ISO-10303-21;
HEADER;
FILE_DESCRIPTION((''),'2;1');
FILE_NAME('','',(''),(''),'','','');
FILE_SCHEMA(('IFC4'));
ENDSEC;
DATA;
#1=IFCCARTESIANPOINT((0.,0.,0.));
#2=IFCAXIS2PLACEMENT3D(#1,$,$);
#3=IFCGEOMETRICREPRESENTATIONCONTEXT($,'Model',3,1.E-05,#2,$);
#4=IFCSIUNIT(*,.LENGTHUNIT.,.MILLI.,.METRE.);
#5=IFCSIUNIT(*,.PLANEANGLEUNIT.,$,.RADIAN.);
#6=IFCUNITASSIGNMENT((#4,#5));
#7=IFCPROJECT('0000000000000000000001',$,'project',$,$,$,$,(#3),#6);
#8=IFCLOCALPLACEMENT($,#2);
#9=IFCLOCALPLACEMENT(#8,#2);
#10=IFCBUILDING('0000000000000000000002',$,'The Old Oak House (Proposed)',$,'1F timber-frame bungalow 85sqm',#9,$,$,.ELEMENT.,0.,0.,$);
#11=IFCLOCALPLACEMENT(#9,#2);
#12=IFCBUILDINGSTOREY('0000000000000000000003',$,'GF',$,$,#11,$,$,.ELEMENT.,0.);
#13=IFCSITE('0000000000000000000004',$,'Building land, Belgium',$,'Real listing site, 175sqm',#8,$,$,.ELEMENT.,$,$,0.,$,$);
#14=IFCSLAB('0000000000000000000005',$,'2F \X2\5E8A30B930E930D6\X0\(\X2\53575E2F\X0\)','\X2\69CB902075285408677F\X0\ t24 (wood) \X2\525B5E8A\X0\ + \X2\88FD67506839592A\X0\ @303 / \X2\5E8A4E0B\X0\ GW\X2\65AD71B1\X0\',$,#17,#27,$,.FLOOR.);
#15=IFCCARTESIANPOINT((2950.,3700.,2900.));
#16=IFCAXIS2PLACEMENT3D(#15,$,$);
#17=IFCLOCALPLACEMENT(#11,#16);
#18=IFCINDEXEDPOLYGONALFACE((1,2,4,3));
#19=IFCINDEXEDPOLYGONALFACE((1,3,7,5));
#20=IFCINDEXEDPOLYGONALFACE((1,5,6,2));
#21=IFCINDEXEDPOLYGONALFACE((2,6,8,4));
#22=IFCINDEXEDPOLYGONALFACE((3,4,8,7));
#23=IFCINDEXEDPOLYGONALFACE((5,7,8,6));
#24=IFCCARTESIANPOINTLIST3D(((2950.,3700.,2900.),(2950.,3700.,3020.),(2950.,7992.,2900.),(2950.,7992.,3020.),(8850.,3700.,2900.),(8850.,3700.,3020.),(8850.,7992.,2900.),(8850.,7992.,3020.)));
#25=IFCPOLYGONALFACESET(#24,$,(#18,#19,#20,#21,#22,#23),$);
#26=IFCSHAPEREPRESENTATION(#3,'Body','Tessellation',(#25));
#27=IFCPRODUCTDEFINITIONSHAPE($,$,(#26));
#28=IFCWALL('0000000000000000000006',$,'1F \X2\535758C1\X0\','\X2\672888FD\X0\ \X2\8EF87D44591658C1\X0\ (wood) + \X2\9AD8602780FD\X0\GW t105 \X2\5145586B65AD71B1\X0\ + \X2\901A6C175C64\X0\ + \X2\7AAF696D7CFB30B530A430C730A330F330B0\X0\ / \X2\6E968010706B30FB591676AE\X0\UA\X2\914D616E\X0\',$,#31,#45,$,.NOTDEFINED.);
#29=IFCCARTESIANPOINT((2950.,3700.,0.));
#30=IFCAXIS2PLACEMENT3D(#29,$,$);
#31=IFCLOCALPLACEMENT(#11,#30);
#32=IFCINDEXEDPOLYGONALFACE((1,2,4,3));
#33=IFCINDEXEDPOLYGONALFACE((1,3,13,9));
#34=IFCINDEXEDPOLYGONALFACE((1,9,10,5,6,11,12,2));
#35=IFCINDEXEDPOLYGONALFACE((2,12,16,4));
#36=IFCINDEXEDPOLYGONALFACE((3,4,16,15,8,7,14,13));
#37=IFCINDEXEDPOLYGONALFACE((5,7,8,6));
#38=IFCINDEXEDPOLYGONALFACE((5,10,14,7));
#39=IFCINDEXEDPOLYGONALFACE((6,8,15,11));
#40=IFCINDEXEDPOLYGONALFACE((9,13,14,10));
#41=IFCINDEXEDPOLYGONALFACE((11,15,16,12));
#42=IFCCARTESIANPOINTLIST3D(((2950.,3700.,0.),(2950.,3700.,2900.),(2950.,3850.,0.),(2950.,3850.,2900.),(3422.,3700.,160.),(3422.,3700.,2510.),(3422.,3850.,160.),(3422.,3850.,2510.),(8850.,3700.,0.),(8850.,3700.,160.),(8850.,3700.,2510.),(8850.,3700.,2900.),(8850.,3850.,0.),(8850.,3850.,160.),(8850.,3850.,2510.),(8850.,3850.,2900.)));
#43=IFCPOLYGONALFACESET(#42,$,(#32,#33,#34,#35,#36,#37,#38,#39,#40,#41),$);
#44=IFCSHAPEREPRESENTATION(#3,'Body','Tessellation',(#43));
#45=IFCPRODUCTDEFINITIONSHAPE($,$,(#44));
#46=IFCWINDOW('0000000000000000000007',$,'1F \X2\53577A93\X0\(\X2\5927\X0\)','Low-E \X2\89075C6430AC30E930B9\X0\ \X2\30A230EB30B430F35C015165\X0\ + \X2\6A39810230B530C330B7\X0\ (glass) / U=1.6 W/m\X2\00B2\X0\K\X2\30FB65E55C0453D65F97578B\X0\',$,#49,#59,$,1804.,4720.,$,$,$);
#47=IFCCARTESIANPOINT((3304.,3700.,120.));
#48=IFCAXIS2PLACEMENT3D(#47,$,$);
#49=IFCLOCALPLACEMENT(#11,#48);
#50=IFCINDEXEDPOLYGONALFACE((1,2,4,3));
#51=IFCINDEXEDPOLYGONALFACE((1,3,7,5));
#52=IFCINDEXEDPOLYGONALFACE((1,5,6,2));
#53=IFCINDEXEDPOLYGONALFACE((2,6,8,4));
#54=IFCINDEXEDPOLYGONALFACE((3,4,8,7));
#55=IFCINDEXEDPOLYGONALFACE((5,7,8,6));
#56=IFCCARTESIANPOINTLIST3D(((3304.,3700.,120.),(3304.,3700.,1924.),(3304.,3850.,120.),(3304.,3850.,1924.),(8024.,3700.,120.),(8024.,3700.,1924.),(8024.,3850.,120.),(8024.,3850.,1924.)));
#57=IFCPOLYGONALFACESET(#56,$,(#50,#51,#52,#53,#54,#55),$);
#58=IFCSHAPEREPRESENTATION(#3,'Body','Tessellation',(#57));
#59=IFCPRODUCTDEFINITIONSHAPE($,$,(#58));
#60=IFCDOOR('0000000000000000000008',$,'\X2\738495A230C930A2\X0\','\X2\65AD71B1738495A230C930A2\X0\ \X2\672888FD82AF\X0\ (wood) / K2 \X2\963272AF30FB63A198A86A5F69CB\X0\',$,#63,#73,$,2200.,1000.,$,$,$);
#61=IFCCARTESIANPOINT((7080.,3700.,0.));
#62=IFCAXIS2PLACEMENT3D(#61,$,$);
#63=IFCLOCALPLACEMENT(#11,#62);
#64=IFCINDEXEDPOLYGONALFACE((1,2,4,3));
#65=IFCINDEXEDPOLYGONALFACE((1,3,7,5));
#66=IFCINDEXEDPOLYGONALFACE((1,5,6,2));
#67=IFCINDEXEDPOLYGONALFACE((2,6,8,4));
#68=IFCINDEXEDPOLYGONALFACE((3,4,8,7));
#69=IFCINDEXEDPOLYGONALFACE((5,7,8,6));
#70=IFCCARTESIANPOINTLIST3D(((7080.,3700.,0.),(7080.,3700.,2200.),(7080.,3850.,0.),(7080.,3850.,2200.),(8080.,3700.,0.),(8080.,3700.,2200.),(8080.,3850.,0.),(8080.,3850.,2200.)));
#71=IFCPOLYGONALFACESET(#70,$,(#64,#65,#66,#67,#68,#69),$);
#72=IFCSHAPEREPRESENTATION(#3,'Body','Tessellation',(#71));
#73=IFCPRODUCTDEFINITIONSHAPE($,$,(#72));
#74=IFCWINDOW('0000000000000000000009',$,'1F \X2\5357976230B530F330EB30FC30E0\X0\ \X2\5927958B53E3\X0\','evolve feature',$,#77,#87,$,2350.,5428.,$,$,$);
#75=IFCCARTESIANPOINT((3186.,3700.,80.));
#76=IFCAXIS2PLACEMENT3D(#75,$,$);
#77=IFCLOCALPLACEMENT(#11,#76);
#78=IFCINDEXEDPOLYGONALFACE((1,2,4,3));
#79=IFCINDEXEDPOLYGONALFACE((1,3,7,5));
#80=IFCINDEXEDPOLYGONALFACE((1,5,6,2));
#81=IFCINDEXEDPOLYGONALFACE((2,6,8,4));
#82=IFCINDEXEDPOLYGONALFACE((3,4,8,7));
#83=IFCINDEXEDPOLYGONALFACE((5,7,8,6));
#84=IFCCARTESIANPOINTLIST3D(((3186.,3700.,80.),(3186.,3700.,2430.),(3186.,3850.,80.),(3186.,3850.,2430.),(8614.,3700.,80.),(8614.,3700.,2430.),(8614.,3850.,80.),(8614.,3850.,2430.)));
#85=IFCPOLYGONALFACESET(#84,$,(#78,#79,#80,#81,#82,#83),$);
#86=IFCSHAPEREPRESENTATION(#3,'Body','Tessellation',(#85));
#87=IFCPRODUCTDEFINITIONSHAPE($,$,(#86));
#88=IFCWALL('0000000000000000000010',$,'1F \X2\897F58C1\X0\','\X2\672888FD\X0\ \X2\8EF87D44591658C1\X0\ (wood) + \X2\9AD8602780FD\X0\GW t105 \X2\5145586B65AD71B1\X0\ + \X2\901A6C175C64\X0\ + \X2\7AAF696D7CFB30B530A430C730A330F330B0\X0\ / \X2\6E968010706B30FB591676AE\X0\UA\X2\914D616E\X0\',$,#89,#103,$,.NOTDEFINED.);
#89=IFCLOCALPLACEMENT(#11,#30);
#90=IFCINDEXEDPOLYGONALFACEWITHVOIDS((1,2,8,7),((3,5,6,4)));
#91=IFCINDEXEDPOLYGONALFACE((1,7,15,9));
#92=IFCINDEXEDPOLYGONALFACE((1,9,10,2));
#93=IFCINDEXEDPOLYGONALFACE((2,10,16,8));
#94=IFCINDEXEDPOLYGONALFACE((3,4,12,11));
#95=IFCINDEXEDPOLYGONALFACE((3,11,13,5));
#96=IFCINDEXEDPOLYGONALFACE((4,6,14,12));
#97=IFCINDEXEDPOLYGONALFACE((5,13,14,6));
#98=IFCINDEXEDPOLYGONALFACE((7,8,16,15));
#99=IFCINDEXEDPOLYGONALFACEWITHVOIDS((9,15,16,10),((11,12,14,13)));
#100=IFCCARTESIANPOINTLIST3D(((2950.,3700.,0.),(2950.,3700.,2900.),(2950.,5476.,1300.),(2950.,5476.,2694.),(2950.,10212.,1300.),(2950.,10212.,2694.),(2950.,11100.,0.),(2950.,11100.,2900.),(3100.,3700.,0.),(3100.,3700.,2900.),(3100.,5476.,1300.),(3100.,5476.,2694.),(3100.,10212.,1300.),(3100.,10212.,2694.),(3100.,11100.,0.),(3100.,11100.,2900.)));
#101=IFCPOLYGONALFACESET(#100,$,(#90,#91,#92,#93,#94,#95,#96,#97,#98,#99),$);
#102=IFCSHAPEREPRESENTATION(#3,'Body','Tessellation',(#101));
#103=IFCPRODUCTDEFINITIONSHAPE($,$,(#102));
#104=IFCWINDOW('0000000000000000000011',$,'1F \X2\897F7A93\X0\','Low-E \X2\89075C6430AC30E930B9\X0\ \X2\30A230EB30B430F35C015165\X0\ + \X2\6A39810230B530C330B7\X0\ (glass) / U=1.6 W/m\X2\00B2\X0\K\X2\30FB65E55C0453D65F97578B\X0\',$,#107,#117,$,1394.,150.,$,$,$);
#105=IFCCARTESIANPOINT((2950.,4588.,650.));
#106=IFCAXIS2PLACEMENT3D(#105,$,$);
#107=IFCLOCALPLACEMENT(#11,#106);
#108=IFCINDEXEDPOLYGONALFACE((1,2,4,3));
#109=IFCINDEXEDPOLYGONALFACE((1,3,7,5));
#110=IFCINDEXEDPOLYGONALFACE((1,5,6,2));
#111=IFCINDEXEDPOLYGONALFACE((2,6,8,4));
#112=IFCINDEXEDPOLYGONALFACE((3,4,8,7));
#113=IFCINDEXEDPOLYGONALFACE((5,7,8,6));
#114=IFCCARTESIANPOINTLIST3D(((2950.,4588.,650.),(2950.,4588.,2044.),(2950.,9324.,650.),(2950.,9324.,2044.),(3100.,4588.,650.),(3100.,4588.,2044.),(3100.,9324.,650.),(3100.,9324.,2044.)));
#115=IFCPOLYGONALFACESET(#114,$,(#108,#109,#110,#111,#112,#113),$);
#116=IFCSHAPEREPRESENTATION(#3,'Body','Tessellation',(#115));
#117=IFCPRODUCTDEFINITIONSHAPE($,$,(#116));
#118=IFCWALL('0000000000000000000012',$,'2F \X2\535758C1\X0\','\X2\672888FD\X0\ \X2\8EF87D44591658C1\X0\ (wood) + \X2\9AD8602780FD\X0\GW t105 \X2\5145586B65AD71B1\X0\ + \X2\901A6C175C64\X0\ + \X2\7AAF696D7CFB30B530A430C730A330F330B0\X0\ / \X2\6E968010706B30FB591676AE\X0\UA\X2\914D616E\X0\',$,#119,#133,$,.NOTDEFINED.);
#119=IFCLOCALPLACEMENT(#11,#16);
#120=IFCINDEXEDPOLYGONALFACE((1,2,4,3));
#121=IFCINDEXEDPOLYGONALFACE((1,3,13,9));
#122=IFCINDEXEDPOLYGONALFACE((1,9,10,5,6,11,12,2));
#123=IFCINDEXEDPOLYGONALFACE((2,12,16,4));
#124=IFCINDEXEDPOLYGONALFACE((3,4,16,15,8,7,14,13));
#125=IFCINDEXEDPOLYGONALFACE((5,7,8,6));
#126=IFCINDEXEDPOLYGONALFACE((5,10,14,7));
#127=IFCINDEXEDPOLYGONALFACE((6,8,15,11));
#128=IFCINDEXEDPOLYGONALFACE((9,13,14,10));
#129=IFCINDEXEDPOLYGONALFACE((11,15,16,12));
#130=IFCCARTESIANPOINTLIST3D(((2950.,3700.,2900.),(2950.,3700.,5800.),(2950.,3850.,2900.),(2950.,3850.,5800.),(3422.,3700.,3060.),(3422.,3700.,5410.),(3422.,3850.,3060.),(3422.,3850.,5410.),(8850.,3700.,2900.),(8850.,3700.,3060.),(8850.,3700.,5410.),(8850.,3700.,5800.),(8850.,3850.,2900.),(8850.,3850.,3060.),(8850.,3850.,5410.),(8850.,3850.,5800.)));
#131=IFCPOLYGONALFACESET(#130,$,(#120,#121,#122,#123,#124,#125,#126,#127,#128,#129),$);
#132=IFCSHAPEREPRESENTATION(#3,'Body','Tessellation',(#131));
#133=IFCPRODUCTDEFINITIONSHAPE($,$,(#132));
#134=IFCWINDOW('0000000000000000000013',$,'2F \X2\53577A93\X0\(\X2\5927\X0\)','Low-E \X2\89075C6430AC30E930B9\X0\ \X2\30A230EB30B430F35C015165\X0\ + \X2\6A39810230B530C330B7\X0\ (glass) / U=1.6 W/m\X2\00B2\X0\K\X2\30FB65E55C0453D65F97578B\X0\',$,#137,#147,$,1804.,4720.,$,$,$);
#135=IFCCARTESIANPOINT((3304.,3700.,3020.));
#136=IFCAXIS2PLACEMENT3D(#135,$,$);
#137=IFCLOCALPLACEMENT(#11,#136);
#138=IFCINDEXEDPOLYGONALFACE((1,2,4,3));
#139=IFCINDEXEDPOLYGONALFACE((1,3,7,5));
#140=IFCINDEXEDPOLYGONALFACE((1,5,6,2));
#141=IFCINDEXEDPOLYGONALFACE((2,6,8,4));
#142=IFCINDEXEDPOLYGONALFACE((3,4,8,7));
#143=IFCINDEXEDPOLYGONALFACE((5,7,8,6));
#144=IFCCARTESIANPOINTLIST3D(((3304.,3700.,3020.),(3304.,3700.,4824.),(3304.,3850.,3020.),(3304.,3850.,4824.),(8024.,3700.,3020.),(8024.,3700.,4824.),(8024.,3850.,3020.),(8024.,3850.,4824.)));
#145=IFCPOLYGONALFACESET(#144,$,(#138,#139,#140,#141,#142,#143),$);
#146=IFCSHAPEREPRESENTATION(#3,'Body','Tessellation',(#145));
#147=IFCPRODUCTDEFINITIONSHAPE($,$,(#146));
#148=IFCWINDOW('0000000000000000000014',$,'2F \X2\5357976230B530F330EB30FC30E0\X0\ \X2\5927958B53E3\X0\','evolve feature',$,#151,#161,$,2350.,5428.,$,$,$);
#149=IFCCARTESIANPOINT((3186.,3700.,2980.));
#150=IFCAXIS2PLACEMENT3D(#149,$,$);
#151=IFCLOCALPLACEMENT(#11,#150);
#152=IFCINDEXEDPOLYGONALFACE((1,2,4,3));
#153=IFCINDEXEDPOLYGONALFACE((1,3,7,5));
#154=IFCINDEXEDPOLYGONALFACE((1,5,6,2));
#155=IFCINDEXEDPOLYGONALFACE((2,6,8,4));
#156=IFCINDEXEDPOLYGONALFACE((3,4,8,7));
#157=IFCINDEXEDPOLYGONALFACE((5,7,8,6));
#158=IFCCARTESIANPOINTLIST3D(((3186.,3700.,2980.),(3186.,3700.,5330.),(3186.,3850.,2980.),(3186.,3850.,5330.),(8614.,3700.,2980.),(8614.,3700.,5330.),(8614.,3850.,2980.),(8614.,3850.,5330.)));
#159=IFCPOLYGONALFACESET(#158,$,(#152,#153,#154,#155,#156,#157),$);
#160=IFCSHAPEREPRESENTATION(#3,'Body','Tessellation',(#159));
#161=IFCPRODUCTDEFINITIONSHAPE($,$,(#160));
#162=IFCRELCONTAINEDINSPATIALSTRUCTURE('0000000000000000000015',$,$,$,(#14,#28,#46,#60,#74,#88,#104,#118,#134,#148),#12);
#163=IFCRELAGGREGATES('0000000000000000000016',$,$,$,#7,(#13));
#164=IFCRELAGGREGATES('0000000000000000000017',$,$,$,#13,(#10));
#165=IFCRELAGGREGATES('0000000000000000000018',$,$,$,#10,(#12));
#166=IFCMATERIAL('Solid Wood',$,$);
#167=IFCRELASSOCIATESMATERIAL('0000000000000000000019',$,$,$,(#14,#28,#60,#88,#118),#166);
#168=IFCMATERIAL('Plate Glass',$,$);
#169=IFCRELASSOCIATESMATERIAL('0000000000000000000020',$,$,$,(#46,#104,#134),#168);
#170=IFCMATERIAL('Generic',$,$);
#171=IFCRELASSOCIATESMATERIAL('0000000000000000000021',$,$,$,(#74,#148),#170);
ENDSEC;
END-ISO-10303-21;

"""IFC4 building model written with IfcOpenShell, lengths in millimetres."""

from ifc_helpers import new_model, si_unit, frame, frame_2d, origin, place, context, project, spatial, rectangle, extrude, material, element, fill, save


model = new_model("IFC4")

# Units and contexts
model_context = context("Model", 3, precision=1e-05, world=origin())
ifc_project = project(units=[si_unit("LENGTHUNIT", "METRE", prefix="MILLI"), si_unit("PLANEANGLEUNIT", "RADIAN")], contexts=[model_context])

# Site, building, storey
site_placement = place(None, origin())
site = spatial("IfcSite", under=ifc_project, at=site_placement, Name="Building land, Belgium", ObjectType="Real listing site, 175sqm", CompositionType="ELEMENT", RefElevation=0.0)
building_placement = place(site_placement, origin())
building = spatial("IfcBuilding", under=site, at=building_placement, Name="The Old Oak House (Proposed)", ObjectType="1F timber-frame bungalow 85sqm", CompositionType="ELEMENT", ElevationOfRefHeight=0.0, ElevationOfTerrain=0.0)
storey_placement = place(building_placement, origin())
storey = spatial("IfcBuildingStorey", under=building, at=storey_placement, Name="GF", CompositionType="ELEMENT", Elevation=0.0)

# Slab
ifc_material_1 = material(Name="Solid Wood")
slab_1_placement = place(storey_placement, frame((2950.0, 3700.0, 2900.0)))
element("IfcSlab", 1, at=slab_1_placement, inside=storey, material=ifc_material_1, Name="2F 床スラブ(南帯)", Description="構造用合板 t24 (wood) 剛床 + 製材根太 @303 / 床下 GW断熱", PredefinedType="FLOOR", context=model_context, shape_type="SweptSolid", body=[
    extrude(rectangle(XDim=5900.0, YDim=4292.0, at=frame_2d((2950.0, 2146.0))), frame((2950.0, 3700.0, 2900.0)), (0.0, 0.0, 1.0), 120.0),
])
ifc_material_2 = material(Name="Generic")

# Wall, openings, windows, door
wall_1_placement = place(storey_placement, frame((2950.0, 3700.0, 0.0)))
wall_1 = element("IfcWall", 2, at=wall_1_placement, inside=storey, material=ifc_material_1, Name="1F 南壁", Description="木製 軸組外壁 (wood) + 高性能GW t105 充填断熱 + 通気層 + 窯業系サイディング / 準耐火・外皮UA配慮", PredefinedType="NOTDEFINED", context=model_context, shape_type="SweptSolid", body=[
    extrude(rectangle(XDim=5900.0, YDim=150.0, at=frame_2d((2950.0, 75.0))), frame((2950.0, 3700.0, 0.0)), (0.0, 0.0, 1.0), 2900.0),
])
opening_1_placement = place(storey_placement, frame((3304.0, 3700.0, 120.0)))
opening_1 = element("IfcOpeningElement", 3, at=opening_1_placement, cuts=wall_1, PredefinedType="NOTDEFINED", context=model_context, shape_type="SweptSolid", body=[
    extrude(rectangle(XDim=4720.0, YDim=150.0, at=frame_2d((2360.0, 75.0))), frame((3304.0, 3700.0, 120.0)), (0.0, 0.0, 1.0), 1804.0),
])
opening_2_placement = place(storey_placement, frame((7080.0, 3700.0, 0.0)))
opening_2 = element("IfcOpeningElement", 4, at=opening_2_placement, cuts=wall_1, PredefinedType="NOTDEFINED", context=model_context, shape_type="SweptSolid", body=[
    extrude(rectangle(XDim=1000.0, YDim=150.0, at=frame_2d((500.0, 75.0))), frame((7080.0, 3700.0, 0.0)), (0.0, 0.0, 1.0), 2200.0),
])
opening_3_placement = place(storey_placement, frame((3186.0, 3700.0, 80.0)))
opening_3 = element("IfcOpeningElement", 5, at=opening_3_placement, cuts=wall_1, PredefinedType="NOTDEFINED", context=model_context, shape_type="SweptSolid", body=[
    extrude(rectangle(XDim=5428.0, YDim=150.0, at=frame_2d((2714.0, 75.0))), frame((3186.0, 3700.0, 80.0)), (0.0, 0.0, 1.0), 2350.0),
])
ifc_material_3 = material(Name="Plate Glass")
window_1_placement = place(storey_placement, frame((3304.0, 3700.0, 120.0)))
window_1 = element("IfcWindow", 6, at=window_1_placement, inside=storey, material=ifc_material_3, Name="1F 南窓(大)", Description="Low-E 複層ガラス アルゴン封入 + 樹脂サッシ (glass) / U=1.6 W/m²K・日射取得型", OverallHeight=1804.0, OverallWidth=4720.0, context=model_context, shape_type="SweptSolid", body=[
    extrude(rectangle(XDim=4720.0, YDim=150.0, at=frame_2d((2360.0, 75.0))), frame((3304.0, 3700.0, 120.0)), (0.0, 0.0, 1.0), 1804.0),
])
fill(opening_1, window_1)
door_placement = place(storey_placement, frame((7080.0, 3700.0, 0.0)))
door = element("IfcDoor", 7, at=door_placement, inside=storey, material=ifc_material_1, Name="玄関ドア", Description="断熱玄関ドア 木製芯 (wood) / K2 防犯・採風機構", OverallHeight=2200.0, OverallWidth=1000.0, context=model_context, shape_type="SweptSolid", body=[
    extrude(rectangle(XDim=1000.0, YDim=150.0, at=frame_2d((500.0, 75.0))), frame((7080.0, 3700.0, 0.0)), (0.0, 0.0, 1.0), 2200.0),
])
fill(opening_2, door)
window_2_placement = place(storey_placement, frame((3186.0, 3700.0, 80.0)))
window_2 = element("IfcWindow", 8, at=window_2_placement, inside=storey, material=ifc_material_2, Name="1F 南面サンルーム 大開口", Description="evolve feature", OverallHeight=2350.0, OverallWidth=5428.0, context=model_context, shape_type="SweptSolid", body=[
    extrude(rectangle(XDim=5428.0, YDim=150.0, at=frame_2d((2714.0, 75.0))), frame((3186.0, 3700.0, 80.0)), (0.0, 0.0, 1.0), 2350.0),
])
fill(opening_3, window_2)

# Wall, opening, window
wall_2_placement = place(storey_placement, frame((2950.0, 3700.0, 0.0)))
wall_2 = element("IfcWall", 9, at=wall_2_placement, inside=storey, material=ifc_material_1, Name="1F 西壁", Description="木製 軸組外壁 (wood) + 高性能GW t105 充填断熱 + 通気層 + 窯業系サイディング / 準耐火・外皮UA配慮", PredefinedType="NOTDEFINED", context=model_context, shape_type="SweptSolid", body=[
    extrude(rectangle(XDim=150.0, YDim=7400.0, at=frame_2d((75.0, 3700.0))), frame((2950.0, 3700.0, 0.0)), (0.0, 0.0, 1.0), 2900.0),
])
opening_4_placement = place(storey_placement, frame((2950.0, 4588.0, 650.0)))
opening_4 = element("IfcOpeningElement", 10, at=opening_4_placement, cuts=wall_2, PredefinedType="NOTDEFINED", context=model_context, shape_type="SweptSolid", body=[
    extrude(rectangle(XDim=150.0, YDim=4736.0, at=frame_2d((75.0, 2368.0))), frame((2950.0, 4588.0, 650.0)), (0.0, 0.0, 1.0), 1394.0),
])
window_3_placement = place(storey_placement, frame((2950.0, 4588.0, 650.0)))
window_3 = element("IfcWindow", 11, at=window_3_placement, inside=storey, material=ifc_material_3, Name="1F 西窓", Description="Low-E 複層ガラス アルゴン封入 + 樹脂サッシ (glass) / U=1.6 W/m²K・日射取得型", OverallHeight=1394.0, OverallWidth=150.0, context=model_context, shape_type="SweptSolid", body=[
    extrude(rectangle(XDim=150.0, YDim=4736.0, at=frame_2d((75.0, 2368.0))), frame((2950.0, 4588.0, 650.0)), (0.0, 0.0, 1.0), 1394.0),
])
fill(opening_4, window_3)

# Wall, openings, windows
wall_3_placement = place(storey_placement, frame((2950.0, 3700.0, 2900.0)))
wall_3 = element("IfcWall", 12, at=wall_3_placement, inside=storey, material=ifc_material_1, Name="2F 南壁", Description="木製 軸組外壁 (wood) + 高性能GW t105 充填断熱 + 通気層 + 窯業系サイディング / 準耐火・外皮UA配慮", PredefinedType="NOTDEFINED", context=model_context, shape_type="SweptSolid", body=[
    extrude(rectangle(XDim=5900.0, YDim=150.0, at=frame_2d((2950.0, 75.0))), frame((2950.0, 3700.0, 2900.0)), (0.0, 0.0, 1.0), 2900.0),
])
opening_5_placement = place(storey_placement, frame((3304.0, 3700.0, 3020.0)))
opening_5 = element("IfcOpeningElement", 13, at=opening_5_placement, cuts=wall_3, PredefinedType="NOTDEFINED", context=model_context, shape_type="SweptSolid", body=[
    extrude(rectangle(XDim=4720.0, YDim=150.0, at=frame_2d((2360.0, 75.0))), frame((3304.0, 3700.0, 3020.0)), (0.0, 0.0, 1.0), 1804.0),
])
opening_6_placement = place(storey_placement, frame((3186.0, 3700.0, 2980.0)))
opening_6 = element("IfcOpeningElement", 14, at=opening_6_placement, cuts=wall_3, PredefinedType="NOTDEFINED", context=model_context, shape_type="SweptSolid", body=[
    extrude(rectangle(XDim=5428.0, YDim=150.0, at=frame_2d((2714.0, 75.0))), frame((3186.0, 3700.0, 2980.0)), (0.0, 0.0, 1.0), 2350.0),
])
window_4_placement = place(storey_placement, frame((3304.0, 3700.0, 3020.0)))
window_4 = element("IfcWindow", 15, at=window_4_placement, inside=storey, material=ifc_material_3, Name="2F 南窓(大)", Description="Low-E 複層ガラス アルゴン封入 + 樹脂サッシ (glass) / U=1.6 W/m²K・日射取得型", OverallHeight=1804.0, OverallWidth=4720.0, context=model_context, shape_type="SweptSolid", body=[
    extrude(rectangle(XDim=4720.0, YDim=150.0, at=frame_2d((2360.0, 75.0))), frame((3304.0, 3700.0, 3020.0)), (0.0, 0.0, 1.0), 1804.0),
])
fill(opening_5, window_4)
window_5_placement = place(storey_placement, frame((3186.0, 3700.0, 2980.0)))
window_5 = element("IfcWindow", 16, at=window_5_placement, inside=storey, material=ifc_material_2, Name="2F 南面サンルーム 大開口", Description="evolve feature", OverallHeight=2350.0, OverallWidth=5428.0, context=model_context, shape_type="SweptSolid", body=[
    extrude(rectangle(XDim=5428.0, YDim=150.0, at=frame_2d((2714.0, 75.0))), frame((3186.0, 3700.0, 2980.0)), (0.0, 0.0, 1.0), 2350.0),
])
fill(opening_6, window_5)

save(model, "model.ifc")
